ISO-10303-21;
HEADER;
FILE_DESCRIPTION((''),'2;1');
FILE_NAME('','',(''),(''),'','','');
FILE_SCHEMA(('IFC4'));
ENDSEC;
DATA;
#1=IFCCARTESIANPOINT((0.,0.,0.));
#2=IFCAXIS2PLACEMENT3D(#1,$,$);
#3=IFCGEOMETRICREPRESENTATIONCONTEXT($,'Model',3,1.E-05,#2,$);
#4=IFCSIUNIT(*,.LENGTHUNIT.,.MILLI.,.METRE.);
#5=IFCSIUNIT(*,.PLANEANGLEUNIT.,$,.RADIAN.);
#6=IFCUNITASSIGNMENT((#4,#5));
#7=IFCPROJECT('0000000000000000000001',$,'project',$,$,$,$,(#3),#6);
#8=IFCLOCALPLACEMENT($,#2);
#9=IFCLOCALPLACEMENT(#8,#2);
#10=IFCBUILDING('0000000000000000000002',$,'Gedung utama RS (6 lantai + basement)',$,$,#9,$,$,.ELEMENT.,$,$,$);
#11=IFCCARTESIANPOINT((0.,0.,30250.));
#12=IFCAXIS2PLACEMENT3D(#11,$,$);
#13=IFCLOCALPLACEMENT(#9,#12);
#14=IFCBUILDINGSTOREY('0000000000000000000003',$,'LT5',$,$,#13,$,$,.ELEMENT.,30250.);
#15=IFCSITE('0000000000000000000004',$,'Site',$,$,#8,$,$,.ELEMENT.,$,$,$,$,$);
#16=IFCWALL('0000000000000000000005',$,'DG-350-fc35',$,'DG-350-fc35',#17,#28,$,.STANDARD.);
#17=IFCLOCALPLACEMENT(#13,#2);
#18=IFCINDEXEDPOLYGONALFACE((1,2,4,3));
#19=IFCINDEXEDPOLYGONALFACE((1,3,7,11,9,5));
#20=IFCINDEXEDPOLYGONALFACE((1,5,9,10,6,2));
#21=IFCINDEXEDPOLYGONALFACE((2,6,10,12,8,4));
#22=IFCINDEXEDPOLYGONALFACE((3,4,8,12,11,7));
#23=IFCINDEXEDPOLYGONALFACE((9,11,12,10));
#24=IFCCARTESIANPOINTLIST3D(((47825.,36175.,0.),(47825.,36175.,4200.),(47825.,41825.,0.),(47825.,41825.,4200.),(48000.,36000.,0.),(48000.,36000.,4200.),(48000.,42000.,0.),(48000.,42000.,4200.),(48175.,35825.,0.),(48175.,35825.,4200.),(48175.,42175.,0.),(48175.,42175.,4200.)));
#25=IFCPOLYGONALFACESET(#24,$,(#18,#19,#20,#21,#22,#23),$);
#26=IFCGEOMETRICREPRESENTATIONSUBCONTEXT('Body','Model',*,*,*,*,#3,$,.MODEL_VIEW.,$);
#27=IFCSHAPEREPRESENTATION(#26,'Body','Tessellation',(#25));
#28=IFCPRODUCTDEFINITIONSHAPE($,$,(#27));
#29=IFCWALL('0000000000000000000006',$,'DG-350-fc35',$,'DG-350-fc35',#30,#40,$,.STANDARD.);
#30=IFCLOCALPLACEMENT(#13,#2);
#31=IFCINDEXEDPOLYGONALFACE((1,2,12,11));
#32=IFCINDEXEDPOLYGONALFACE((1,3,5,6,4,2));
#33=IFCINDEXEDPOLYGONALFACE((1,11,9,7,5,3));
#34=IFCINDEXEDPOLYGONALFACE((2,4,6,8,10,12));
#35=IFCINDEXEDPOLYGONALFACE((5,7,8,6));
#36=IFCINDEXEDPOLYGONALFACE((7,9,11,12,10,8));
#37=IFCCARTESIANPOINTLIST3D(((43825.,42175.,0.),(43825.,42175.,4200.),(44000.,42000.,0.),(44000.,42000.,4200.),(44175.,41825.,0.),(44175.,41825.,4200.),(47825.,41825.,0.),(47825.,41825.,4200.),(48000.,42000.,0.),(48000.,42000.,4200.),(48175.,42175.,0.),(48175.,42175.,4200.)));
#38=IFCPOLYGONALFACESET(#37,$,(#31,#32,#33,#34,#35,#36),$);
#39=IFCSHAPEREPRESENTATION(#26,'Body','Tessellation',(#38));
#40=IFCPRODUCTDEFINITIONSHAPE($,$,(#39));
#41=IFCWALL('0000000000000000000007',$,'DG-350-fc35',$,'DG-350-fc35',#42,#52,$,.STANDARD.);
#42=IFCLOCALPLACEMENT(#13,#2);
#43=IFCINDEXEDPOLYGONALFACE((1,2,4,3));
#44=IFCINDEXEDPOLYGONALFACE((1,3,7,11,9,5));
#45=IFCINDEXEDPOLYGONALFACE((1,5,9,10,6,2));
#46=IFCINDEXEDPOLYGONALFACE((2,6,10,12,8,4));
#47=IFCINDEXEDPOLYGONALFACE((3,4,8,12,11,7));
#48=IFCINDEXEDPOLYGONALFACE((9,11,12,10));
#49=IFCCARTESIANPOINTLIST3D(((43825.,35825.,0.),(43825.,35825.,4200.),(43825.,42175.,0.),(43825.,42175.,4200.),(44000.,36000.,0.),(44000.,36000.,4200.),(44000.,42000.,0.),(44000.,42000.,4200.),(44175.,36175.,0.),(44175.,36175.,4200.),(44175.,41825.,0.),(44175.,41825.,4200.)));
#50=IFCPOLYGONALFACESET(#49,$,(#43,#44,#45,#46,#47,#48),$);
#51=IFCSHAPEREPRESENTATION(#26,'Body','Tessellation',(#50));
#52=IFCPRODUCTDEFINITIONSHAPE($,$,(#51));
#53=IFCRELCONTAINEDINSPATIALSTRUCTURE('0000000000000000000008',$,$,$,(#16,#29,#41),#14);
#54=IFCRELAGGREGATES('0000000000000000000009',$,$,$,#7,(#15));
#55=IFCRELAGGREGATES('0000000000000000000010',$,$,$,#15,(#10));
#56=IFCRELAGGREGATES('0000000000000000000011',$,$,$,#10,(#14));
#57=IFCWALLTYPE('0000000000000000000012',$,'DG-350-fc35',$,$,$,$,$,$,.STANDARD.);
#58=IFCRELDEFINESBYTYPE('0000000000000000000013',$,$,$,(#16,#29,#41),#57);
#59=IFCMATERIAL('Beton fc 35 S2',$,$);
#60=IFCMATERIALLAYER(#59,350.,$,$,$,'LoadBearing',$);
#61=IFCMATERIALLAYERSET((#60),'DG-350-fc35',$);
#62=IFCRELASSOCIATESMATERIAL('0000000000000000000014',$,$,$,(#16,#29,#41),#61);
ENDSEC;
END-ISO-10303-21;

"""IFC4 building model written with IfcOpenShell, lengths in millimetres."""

from ifc_helpers import new_model, si_unit, frame, origin, place, context, subcontext, project, spatial, polyline, outline, extrude, material, layer, layer_set, layer_usage, type_object, element, save


model = new_model("IFC4")

# Units and contexts
model_context = context("Model", 3, precision=1e-05, world=origin())
body_context = subcontext(model_context, "Body", "Model", "MODEL_VIEW")
ifc_project = project(units=[si_unit("LENGTHUNIT", "METRE", prefix="MILLI"), si_unit("PLANEANGLEUNIT", "RADIAN")], contexts=[model_context])

# Site, building, storey
site_placement = place(None, origin())
site = spatial("IfcSite", under=ifc_project, at=site_placement, Name="Site", CompositionType="ELEMENT")
building_placement = place(site_placement, origin())
building = spatial("IfcBuilding", under=site, at=building_placement, Name="Gedung utama RS (6 lantai + basement)", CompositionType="ELEMENT")
storey_placement = place(building_placement, frame((0.0, 0.0, 30250.0)))
storey = spatial("IfcBuildingStorey", under=building, at=storey_placement, Name="LT5", CompositionType="ELEMENT", Elevation=30250.0)

# Shared definitions
ifc_material_1 = material(Name="Beton fc 35 S2")
ifc_layer = layer(ifc_material_1, 350.0, Category="LoadBearing")
ifc_layer_set = layer_set([ifc_layer], Name="DG-350-fc35")
ifc_layer_usage = layer_usage(ifc_layer_set, "AXIS2", "NEGATIVE", 175.0)
wall_type = type_object("IfcWallType", Name="DG-350-fc35", PredefinedType="STANDARD")

# Walls
wall_1_placement = place(storey_placement, frame((48000.0, 36000.0, 0.0), z_axis=(0.0, 0.0, 1.0), x_axis=(0.0, 1.0, 0.0)))
element("IfcWall", 1, at=wall_1_placement, inside=storey, type_object=wall_type, material=ifc_layer_usage, Name="DG-350-fc35", ObjectType="DG-350-fc35", PredefinedType="STANDARD", context=body_context, shape_type="SweptSolid", body=[
    extrude(outline(polyline([(-175.0, -175.0), (0.0, 0.0), (175.0, 175.0), (5825.0, 175.0), (6000.0, 0.0), (6175.0, -175.0), (-175.0, -175.0)])), origin(), (0.0, 0.0, 1.0), 4200.0),
])
wall_2_placement = place(storey_placement, frame((48000.0, 42000.0, 0.0), z_axis=(0.0, 0.0, 1.0), x_axis=(-1.0, 0.0, 0.0)))
element("IfcWall", 2, at=wall_2_placement, inside=storey, type_object=wall_type, material=ifc_layer_usage, Name="DG-350-fc35", ObjectType="DG-350-fc35", PredefinedType="STANDARD", context=body_context, shape_type="SweptSolid", body=[
    extrude(outline(polyline([(-175.0, -175.0), (0.0, 0.0), (175.0, 175.0), (3825.0, 175.0), (4000.0, 0.0), (4175.0, -175.0), (-175.0, -175.0)])), origin(), (0.0, 0.0, 1.0), 4200.0),
])
wall_3_placement = place(storey_placement, frame((44000.0, 42000.0, 0.0), z_axis=(0.0, 0.0, 1.0), x_axis=(0.0, -1.0, 0.0)))
element("IfcWall", 3, at=wall_3_placement, inside=storey, type_object=wall_type, material=ifc_layer_usage, Name="DG-350-fc35", ObjectType="DG-350-fc35", PredefinedType="STANDARD", context=body_context, shape_type="SweptSolid", body=[
    extrude(outline(polyline([(-175.0, -175.0), (0.0, 0.0), (175.0, 175.0), (5825.0, 175.0), (6000.0, 0.0), (6175.0, -175.0), (-175.0, -175.0)])), origin(), (0.0, 0.0, 1.0), 4200.0),
])

save(model, "model.ifc")
